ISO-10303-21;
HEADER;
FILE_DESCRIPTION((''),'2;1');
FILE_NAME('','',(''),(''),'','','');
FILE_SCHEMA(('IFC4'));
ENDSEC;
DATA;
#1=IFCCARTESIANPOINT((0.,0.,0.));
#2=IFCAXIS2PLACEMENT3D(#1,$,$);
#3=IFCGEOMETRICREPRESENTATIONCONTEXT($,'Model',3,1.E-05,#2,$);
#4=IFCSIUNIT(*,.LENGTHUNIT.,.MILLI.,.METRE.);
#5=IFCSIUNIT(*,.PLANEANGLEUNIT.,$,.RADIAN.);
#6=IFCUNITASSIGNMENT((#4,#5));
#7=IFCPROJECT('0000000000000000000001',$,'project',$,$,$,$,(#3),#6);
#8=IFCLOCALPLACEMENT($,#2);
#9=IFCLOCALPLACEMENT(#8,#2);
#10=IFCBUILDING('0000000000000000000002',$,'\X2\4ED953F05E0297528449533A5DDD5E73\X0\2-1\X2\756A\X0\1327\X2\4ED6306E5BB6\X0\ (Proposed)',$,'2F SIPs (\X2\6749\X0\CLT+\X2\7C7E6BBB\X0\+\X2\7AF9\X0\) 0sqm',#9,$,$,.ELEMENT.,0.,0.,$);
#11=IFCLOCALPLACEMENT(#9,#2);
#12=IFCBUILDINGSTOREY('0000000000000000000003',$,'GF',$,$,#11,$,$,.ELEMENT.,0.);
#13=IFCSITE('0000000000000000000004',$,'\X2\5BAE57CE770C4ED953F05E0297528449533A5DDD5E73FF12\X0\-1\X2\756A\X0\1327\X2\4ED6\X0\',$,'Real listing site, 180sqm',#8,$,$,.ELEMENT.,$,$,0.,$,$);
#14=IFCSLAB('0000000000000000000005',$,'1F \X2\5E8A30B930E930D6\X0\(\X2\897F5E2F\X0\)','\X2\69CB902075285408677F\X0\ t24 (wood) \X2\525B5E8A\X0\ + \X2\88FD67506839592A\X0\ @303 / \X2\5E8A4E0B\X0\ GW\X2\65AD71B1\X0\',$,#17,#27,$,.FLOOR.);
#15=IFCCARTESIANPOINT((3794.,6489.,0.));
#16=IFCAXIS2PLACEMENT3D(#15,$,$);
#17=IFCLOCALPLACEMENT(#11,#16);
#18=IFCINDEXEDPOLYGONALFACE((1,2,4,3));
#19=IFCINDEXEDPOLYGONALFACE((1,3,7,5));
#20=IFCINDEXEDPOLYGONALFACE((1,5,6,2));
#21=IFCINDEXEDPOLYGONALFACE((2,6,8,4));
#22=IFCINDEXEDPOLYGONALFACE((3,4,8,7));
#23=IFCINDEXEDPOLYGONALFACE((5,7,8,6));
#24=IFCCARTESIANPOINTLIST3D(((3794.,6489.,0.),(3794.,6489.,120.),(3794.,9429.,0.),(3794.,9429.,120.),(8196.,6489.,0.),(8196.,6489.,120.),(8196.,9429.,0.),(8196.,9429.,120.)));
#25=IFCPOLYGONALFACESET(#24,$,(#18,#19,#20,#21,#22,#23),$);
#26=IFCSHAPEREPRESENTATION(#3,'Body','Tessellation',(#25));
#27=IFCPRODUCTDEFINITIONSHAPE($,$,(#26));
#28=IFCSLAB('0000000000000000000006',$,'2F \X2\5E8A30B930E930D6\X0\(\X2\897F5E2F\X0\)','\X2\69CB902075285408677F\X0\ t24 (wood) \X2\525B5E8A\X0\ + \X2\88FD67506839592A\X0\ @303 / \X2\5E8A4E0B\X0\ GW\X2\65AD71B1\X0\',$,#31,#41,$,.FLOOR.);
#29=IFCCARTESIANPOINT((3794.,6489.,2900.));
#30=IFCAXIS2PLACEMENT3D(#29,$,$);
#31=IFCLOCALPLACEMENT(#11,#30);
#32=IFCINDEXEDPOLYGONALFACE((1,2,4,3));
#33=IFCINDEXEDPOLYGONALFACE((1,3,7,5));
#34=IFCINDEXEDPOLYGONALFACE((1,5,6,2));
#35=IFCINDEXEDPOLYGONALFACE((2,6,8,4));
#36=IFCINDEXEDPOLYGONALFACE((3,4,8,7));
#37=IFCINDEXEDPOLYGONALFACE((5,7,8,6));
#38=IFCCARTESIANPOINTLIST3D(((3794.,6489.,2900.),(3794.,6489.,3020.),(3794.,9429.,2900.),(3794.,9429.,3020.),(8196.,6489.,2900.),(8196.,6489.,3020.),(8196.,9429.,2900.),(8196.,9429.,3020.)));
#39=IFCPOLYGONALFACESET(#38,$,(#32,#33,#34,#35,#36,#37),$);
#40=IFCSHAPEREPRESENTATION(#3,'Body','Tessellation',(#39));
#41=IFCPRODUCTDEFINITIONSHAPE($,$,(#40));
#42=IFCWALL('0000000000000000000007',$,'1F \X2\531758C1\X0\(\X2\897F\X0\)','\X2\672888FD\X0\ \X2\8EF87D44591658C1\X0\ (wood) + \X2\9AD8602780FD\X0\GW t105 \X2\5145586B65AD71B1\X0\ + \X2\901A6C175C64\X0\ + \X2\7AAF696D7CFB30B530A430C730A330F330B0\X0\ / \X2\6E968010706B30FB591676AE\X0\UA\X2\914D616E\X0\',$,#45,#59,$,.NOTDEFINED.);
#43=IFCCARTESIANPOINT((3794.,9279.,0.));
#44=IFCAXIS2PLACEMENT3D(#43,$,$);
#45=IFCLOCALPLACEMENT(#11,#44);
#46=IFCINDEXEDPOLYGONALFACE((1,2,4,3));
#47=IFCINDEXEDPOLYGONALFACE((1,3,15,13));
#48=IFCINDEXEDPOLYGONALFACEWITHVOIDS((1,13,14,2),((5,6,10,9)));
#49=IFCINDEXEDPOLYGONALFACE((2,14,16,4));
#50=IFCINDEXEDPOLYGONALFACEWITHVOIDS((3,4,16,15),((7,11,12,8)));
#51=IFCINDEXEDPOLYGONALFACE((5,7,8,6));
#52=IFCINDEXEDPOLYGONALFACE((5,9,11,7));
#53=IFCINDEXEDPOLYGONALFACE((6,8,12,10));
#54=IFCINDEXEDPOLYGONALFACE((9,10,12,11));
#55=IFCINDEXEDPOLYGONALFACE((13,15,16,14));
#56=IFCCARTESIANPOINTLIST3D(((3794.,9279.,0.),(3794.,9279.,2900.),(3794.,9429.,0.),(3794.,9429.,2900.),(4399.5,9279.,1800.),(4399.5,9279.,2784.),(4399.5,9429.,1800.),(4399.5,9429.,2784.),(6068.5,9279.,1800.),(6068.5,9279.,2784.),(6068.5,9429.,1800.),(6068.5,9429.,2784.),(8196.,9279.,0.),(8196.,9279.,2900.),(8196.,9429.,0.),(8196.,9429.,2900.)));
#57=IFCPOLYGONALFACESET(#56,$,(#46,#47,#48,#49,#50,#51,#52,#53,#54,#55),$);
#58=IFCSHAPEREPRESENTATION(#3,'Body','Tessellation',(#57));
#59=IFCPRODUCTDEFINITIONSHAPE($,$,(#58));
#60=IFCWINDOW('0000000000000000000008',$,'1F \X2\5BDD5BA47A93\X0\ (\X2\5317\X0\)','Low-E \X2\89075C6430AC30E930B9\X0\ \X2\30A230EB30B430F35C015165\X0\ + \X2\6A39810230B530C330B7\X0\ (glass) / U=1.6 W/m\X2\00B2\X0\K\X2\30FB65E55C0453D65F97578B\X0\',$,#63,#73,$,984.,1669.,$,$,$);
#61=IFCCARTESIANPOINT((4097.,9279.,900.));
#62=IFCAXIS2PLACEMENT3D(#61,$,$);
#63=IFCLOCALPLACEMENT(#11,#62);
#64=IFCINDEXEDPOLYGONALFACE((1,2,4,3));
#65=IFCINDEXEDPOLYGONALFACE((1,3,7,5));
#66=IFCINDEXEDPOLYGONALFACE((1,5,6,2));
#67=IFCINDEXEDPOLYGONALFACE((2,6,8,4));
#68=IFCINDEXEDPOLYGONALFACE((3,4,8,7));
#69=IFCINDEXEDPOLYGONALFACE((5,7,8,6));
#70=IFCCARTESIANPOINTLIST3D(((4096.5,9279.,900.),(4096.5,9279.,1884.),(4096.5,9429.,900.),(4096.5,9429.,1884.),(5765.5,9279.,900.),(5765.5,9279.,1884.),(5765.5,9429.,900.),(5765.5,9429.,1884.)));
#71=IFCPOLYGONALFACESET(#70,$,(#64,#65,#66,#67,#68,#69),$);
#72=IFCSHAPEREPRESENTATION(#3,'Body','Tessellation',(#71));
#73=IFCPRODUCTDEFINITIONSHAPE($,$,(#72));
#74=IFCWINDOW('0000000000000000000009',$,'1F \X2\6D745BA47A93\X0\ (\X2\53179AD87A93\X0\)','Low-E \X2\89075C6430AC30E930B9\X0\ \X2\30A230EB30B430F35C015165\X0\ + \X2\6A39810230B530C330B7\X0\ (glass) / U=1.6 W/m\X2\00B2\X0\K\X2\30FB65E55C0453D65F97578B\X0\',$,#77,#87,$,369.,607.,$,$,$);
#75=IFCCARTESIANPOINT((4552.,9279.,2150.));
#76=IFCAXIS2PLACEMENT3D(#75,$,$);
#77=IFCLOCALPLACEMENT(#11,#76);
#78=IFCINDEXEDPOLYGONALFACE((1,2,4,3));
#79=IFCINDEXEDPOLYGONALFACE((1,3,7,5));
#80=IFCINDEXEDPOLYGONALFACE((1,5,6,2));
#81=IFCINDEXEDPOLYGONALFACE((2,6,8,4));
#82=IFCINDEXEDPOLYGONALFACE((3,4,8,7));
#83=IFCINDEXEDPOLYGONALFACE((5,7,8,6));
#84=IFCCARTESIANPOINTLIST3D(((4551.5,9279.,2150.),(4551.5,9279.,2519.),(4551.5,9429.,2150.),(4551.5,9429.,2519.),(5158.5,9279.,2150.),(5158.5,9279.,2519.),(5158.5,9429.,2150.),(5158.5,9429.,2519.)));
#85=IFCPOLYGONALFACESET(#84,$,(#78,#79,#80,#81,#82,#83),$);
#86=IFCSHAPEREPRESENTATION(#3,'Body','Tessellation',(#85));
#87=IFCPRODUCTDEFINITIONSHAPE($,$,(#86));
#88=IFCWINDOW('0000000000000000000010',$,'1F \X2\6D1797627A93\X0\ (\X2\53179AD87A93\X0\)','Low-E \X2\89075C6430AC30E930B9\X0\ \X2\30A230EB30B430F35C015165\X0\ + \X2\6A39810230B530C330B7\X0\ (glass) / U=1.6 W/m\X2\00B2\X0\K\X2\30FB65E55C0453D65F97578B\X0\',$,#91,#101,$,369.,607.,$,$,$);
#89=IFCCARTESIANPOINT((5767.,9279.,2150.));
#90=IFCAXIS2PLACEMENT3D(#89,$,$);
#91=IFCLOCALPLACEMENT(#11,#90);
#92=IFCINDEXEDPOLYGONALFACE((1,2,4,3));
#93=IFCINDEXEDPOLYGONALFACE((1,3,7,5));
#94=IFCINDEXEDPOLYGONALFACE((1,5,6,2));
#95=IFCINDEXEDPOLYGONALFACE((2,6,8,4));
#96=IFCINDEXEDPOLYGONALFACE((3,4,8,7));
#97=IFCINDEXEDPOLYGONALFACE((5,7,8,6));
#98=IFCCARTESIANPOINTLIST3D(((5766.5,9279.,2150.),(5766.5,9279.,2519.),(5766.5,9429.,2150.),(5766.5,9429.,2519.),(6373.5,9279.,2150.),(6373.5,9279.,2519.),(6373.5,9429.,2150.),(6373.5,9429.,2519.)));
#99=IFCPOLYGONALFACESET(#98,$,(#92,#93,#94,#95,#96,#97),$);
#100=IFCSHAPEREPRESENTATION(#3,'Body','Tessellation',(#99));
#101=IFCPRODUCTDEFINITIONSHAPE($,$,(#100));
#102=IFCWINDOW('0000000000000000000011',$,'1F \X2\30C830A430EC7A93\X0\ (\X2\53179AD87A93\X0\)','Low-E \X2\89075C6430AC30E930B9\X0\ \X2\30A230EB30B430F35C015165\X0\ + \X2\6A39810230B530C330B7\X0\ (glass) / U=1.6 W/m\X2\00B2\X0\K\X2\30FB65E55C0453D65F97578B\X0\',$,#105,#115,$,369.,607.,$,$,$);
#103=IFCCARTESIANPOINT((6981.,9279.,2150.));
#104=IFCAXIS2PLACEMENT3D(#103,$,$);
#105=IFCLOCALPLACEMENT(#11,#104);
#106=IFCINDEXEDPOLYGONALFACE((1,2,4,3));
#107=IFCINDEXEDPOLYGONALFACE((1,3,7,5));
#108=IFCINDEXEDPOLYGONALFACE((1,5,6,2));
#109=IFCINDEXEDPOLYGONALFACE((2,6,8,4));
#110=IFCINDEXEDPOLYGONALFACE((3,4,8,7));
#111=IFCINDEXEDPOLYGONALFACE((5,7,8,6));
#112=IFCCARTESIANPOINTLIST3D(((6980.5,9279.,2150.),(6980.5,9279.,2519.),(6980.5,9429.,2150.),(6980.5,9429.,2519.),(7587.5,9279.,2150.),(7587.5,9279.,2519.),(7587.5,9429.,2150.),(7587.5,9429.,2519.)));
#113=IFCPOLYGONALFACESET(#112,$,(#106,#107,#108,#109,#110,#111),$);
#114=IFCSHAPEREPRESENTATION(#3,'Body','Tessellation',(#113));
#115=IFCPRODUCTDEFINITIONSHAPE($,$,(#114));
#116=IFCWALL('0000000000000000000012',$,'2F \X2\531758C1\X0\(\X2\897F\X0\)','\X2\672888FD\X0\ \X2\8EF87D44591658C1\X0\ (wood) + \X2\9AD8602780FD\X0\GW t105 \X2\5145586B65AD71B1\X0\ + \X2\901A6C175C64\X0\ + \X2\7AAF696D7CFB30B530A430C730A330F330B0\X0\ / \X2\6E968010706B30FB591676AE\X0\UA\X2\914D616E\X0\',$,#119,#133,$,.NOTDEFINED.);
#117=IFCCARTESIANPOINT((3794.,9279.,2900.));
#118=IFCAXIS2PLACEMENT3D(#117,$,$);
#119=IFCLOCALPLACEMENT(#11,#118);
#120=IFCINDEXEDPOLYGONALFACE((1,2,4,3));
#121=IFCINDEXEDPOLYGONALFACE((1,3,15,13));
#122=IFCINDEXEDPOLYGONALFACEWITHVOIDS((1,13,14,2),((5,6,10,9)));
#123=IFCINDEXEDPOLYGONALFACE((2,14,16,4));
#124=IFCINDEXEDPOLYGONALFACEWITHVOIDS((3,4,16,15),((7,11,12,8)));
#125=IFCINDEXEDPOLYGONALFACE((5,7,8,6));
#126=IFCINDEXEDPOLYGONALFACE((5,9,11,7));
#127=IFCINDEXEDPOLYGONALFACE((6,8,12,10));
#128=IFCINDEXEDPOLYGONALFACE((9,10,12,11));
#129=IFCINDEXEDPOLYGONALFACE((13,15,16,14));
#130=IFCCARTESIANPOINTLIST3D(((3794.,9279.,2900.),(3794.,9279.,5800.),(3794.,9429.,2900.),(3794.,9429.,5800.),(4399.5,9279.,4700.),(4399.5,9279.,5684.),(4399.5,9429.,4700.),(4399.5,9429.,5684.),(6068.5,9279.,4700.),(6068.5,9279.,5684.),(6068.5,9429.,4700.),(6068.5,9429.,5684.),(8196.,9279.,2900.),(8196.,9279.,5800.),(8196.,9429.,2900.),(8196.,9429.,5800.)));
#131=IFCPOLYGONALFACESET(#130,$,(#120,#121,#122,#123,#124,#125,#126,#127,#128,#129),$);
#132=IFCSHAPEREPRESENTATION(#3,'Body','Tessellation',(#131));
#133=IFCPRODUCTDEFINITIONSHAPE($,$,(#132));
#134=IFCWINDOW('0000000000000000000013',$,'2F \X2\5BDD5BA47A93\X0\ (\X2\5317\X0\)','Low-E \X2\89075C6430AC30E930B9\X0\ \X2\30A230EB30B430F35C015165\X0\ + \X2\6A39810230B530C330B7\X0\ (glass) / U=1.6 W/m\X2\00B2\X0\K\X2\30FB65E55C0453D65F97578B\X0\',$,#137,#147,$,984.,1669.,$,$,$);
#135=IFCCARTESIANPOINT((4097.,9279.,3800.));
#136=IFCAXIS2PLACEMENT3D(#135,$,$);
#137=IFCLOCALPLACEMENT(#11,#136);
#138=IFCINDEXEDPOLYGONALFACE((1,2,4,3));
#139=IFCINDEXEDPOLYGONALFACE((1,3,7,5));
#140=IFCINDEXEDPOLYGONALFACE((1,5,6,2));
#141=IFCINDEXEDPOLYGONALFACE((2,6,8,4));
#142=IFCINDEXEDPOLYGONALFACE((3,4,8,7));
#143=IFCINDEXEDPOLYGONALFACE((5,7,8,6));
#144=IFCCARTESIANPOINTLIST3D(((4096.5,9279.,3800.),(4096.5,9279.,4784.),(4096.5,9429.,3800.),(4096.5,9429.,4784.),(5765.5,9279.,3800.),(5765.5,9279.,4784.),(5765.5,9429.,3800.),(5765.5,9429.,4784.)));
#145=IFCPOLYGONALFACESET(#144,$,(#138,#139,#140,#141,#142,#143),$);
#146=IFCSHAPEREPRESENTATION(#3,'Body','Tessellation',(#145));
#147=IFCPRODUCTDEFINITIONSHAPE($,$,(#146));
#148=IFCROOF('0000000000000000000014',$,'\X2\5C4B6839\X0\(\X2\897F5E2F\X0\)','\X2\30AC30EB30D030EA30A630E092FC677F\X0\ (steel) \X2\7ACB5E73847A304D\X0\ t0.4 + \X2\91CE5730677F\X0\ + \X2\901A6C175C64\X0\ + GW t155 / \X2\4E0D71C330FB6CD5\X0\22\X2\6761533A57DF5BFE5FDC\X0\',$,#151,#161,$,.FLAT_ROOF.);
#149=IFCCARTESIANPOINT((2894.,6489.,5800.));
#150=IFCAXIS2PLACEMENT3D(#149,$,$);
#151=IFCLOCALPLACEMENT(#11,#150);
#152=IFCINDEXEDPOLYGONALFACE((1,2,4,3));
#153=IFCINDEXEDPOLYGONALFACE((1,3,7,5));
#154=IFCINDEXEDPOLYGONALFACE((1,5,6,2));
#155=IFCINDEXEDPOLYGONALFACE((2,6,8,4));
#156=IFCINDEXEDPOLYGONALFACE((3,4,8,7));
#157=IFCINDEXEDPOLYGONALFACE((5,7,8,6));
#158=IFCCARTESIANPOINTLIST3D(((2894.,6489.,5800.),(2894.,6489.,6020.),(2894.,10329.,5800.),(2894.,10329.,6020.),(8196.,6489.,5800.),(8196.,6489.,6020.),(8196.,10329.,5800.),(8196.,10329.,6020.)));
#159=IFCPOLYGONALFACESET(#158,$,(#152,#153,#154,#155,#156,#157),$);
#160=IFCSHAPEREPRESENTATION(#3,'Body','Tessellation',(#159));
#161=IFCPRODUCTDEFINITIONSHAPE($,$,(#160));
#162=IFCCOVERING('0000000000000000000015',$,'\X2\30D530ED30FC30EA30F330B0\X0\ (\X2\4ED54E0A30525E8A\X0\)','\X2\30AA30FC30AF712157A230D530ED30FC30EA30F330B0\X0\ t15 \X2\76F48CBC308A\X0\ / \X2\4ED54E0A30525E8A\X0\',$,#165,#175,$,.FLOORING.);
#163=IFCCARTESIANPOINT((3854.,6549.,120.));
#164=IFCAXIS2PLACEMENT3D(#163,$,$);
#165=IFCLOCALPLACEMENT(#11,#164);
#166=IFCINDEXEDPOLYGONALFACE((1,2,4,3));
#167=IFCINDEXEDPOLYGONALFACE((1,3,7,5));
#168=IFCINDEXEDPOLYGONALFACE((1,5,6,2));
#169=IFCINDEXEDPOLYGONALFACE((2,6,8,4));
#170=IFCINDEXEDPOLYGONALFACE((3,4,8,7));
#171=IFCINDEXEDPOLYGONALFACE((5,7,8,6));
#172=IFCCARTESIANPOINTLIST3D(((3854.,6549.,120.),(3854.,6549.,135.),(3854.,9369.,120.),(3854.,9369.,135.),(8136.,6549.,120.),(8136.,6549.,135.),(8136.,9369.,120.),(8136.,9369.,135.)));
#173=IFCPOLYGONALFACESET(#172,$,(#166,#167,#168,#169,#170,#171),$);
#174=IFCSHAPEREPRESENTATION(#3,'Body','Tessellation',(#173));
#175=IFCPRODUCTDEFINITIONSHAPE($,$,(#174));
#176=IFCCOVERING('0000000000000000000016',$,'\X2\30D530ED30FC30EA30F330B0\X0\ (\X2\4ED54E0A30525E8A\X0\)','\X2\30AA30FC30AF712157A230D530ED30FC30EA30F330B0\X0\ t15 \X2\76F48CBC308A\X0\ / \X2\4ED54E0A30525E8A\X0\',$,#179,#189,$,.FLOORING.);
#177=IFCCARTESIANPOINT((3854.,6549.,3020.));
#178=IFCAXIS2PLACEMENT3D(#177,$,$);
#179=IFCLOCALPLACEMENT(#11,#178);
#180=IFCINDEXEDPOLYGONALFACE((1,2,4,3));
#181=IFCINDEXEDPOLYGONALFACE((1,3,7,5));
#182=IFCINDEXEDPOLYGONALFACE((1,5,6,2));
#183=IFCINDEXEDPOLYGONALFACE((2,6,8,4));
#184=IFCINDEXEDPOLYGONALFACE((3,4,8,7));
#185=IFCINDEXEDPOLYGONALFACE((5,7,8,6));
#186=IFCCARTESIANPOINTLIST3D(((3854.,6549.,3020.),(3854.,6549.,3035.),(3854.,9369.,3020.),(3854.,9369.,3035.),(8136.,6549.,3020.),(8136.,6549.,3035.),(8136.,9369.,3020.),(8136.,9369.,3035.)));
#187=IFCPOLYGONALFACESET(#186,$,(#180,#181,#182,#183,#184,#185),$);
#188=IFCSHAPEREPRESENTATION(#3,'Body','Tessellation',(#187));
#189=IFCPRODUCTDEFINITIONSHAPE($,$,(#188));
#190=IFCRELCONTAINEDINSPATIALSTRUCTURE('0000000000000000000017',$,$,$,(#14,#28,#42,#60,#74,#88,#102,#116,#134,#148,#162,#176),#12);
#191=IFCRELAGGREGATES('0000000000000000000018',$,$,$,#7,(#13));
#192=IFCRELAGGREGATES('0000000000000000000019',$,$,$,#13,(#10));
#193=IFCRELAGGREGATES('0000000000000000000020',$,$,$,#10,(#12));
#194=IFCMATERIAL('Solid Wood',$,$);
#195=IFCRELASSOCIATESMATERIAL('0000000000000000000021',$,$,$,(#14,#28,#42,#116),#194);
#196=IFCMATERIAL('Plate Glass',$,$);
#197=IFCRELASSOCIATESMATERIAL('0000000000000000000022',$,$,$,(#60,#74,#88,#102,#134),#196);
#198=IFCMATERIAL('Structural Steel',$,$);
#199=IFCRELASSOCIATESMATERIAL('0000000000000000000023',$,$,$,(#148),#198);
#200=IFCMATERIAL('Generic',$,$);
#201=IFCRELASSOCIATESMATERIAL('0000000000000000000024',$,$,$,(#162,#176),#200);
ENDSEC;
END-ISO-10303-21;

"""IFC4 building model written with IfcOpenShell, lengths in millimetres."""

from ifc_helpers import new_model, si_unit, frame, frame_2d, origin, place, context, project, spatial, rectangle, extrude, material, element, fill, save


model = new_model("IFC4")

# Units and contexts
model_context = context("Model", 3, precision=1e-05, world=origin())
ifc_project = project(units=[si_unit("LENGTHUNIT", "METRE", prefix="MILLI"), si_unit("PLANEANGLEUNIT", "RADIAN")], contexts=[model_context])

# Site, building, storey
site_placement = place(None, origin())
site = spatial("IfcSite", under=ifc_project, at=site_placement, Name="宮城県仙台市青葉区川平２-1番1327他", ObjectType="Real listing site, 180sqm", CompositionType="ELEMENT", RefElevation=0.0)
building_placement = place(site_placement, origin())
building = spatial("IfcBuilding", under=site, at=building_placement, Name="仙台市青葉区川平2-1番1327他の家 (Proposed)", ObjectType="2F SIPs (杉CLT+籾殻+竹) 0sqm", CompositionType="ELEMENT", ElevationOfRefHeight=0.0, ElevationOfTerrain=0.0)
storey_placement = place(building_placement, origin())
storey = spatial("IfcBuildingStorey", under=building, at=storey_placement, Name="GF", CompositionType="ELEMENT", Elevation=0.0)

# Slabs
ifc_material_1 = material(Name="Solid Wood")
slab_1_placement = place(storey_placement, frame((3794.0, 6489.0, 0.0)))
element("IfcSlab", 1, at=slab_1_placement, inside=storey, material=ifc_material_1, Name="1F 床スラブ(西帯)", Description="構造用合板 t24 (wood) 剛床 + 製材根太 @303 / 床下 GW断熱", PredefinedType="FLOOR", context=model_context, shape_type="SweptSolid", body=[
    extrude(rectangle(XDim=4402.0, YDim=2940.0, at=frame_2d((2201.0, 1470.0))), frame((3794.0, 6489.0, 0.0)), (0.0, 0.0, 1.0), 120.0),
])
slab_2_placement = place(storey_placement, frame((3794.0, 6489.0, 2900.0)))
element("IfcSlab", 2, at=slab_2_placement, inside=storey, material=ifc_material_1, Name="2F 床スラブ(西帯)", Description="構造用合板 t24 (wood) 剛床 + 製材根太 @303 / 床下 GW断熱", PredefinedType="FLOOR", context=model_context, shape_type="SweptSolid", body=[
    extrude(rectangle(XDim=4402.0, YDim=2940.0, at=frame_2d((2201.0, 1470.0))), frame((3794.0, 6489.0, 2900.0)), (0.0, 0.0, 1.0), 120.0),
])

# Wall, openings, windows
wall_1_placement = place(storey_placement, frame((3794.0, 9279.0, 0.0)))
wall_1 = element("IfcWall", 3, at=wall_1_placement, inside=storey, material=ifc_material_1, Name="1F 北壁(西)", Description="木製 軸組外壁 (wood) + 高性能GW t105 充填断熱 + 通気層 + 窯業系サイディング / 準耐火・外皮UA配慮", PredefinedType="NOTDEFINED", context=model_context, shape_type="SweptSolid", body=[
    extrude(rectangle(XDim=4402.0, YDim=150.0, at=frame_2d((2201.0, 75.0))), frame((3794.0, 9279.0, 0.0)), (0.0, 0.0, 1.0), 2900.0),
])
opening_1_placement = place(storey_placement, frame((4097.0, 9279.0, 900.0)))
opening_1 = element("IfcOpeningElement", 4, at=opening_1_placement, cuts=wall_1, PredefinedType="NOTDEFINED", context=model_context, shape_type="SweptSolid", body=[
    extrude(rectangle(XDim=1669.0, YDim=150.0, at=frame_2d((834.0, 75.0))), frame((4097.0, 9279.0, 900.0)), (0.0, 0.0, 1.0), 984.0),
])
opening_2_placement = place(storey_placement, frame((4552.0, 9279.0, 2150.0)))
opening_2 = element("IfcOpeningElement", 5, at=opening_2_placement, cuts=wall_1, PredefinedType="NOTDEFINED", context=model_context, shape_type="SweptSolid", body=[
    extrude(rectangle(XDim=607.0, YDim=150.0, at=frame_2d((303.0, 75.0))), frame((4552.0, 9279.0, 2150.0)), (0.0, 0.0, 1.0), 369.0),
])
opening_3_placement = place(storey_placement, frame((5767.0, 9279.0, 2150.0)))
opening_3 = element("IfcOpeningElement", 6, at=opening_3_placement, cuts=wall_1, PredefinedType="NOTDEFINED", context=model_context, shape_type="SweptSolid", body=[
    extrude(rectangle(XDim=607.0, YDim=150.0, at=frame_2d((303.0, 75.0))), frame((5767.0, 9279.0, 2150.0)), (0.0, 0.0, 1.0), 369.0),
])
opening_4_placement = place(storey_placement, frame((6981.0, 9279.0, 2150.0)))
opening_4 = element("IfcOpeningElement", 7, at=opening_4_placement, cuts=wall_1, PredefinedType="NOTDEFINED", context=model_context, shape_type="SweptSolid", body=[
    extrude(rectangle(XDim=607.0, YDim=150.0, at=frame_2d((303.0, 75.0))), frame((6981.0, 9279.0, 2150.0)), (0.0, 0.0, 1.0), 369.0),
])
ifc_material_2 = material(Name="Plate Glass")
window_1_placement = place(storey_placement, frame((4097.0, 9279.0, 900.0)))
window_1 = element("IfcWindow", 8, at=window_1_placement, inside=storey, material=ifc_material_2, Name="1F 寝室窓 (北)", Description="Low-E 複層ガラス アルゴン封入 + 樹脂サッシ (glass) / U=1.6 W/m²K・日射取得型", OverallHeight=984.0, OverallWidth=1669.0, context=model_context, shape_type="SweptSolid", body=[
    extrude(rectangle(XDim=1669.0, YDim=150.0, at=frame_2d((834.0, 75.0))), frame((4097.0, 9279.0, 900.0)), (0.0, 0.0, 1.0), 984.0),
])
fill(opening_1, window_1)
window_2_placement = place(storey_placement, frame((4552.0, 9279.0, 2150.0)))
window_2 = element("IfcWindow", 9, at=window_2_placement, inside=storey, material=ifc_material_2, Name="1F 浴室窓 (北高窓)", Description="Low-E 複層ガラス アルゴン封入 + 樹脂サッシ (glass) / U=1.6 W/m²K・日射取得型", OverallHeight=369.0, OverallWidth=607.0, context=model_context, shape_type="SweptSolid", body=[
    extrude(rectangle(XDim=607.0, YDim=150.0, at=frame_2d((303.0, 75.0))), frame((4552.0, 9279.0, 2150.0)), (0.0, 0.0, 1.0), 369.0),
])
fill(opening_2, window_2)
window_3_placement = place(storey_placement, frame((5767.0, 9279.0, 2150.0)))
window_3 = element("IfcWindow", 10, at=window_3_placement, inside=storey, material=ifc_material_2, Name="1F 洗面窓 (北高窓)", Description="Low-E 複層ガラス アルゴン封入 + 樹脂サッシ (glass) / U=1.6 W/m²K・日射取得型", OverallHeight=369.0, OverallWidth=607.0, context=model_context, shape_type="SweptSolid", body=[
    extrude(rectangle(XDim=607.0, YDim=150.0, at=frame_2d((303.0, 75.0))), frame((5767.0, 9279.0, 2150.0)), (0.0, 0.0, 1.0), 369.0),
])
fill(opening_3, window_3)
window_4_placement = place(storey_placement, frame((6981.0, 9279.0, 2150.0)))
window_4 = element("IfcWindow", 11, at=window_4_placement, inside=storey, material=ifc_material_2, Name="1F トイレ窓 (北高窓)", Description="Low-E 複層ガラス アルゴン封入 + 樹脂サッシ (glass) / U=1.6 W/m²K・日射取得型", OverallHeight=369.0, OverallWidth=607.0, context=model_context, shape_type="SweptSolid", body=[
    extrude(rectangle(XDim=607.0, YDim=150.0, at=frame_2d((303.0, 75.0))), frame((6981.0, 9279.0, 2150.0)), (0.0, 0.0, 1.0), 369.0),
])
fill(opening_4, window_4)

# Wall, opening, window
wall_2_placement = place(storey_placement, frame((3794.0, 9279.0, 2900.0)))
wall_2 = element("IfcWall", 12, at=wall_2_placement, inside=storey, material=ifc_material_1, Name="2F 北壁(西)", Description="木製 軸組外壁 (wood) + 高性能GW t105 充填断熱 + 通気層 + 窯業系サイディング / 準耐火・外皮UA配慮", PredefinedType="NOTDEFINED", context=model_context, shape_type="SweptSolid", body=[
    extrude(rectangle(XDim=4402.0, YDim=150.0, at=frame_2d((2201.0, 75.0))), frame((3794.0, 9279.0, 2900.0)), (0.0, 0.0, 1.0), 2900.0),
])
opening_5_placement = place(storey_placement, frame((4097.0, 9279.0, 3800.0)))
opening_5 = element("IfcOpeningElement", 13, at=opening_5_placement, cuts=wall_2, PredefinedType="NOTDEFINED", context=model_context, shape_type="SweptSolid", body=[
    extrude(rectangle(XDim=1669.0, YDim=150.0, at=frame_2d((834.0, 75.0))), frame((4097.0, 9279.0, 3800.0)), (0.0, 0.0, 1.0), 984.0),
])
window_5_placement = place(storey_placement, frame((4097.0, 9279.0, 3800.0)))
window_5 = element("IfcWindow", 14, at=window_5_placement, inside=storey, material=ifc_material_2, Name="2F 寝室窓 (北)", Description="Low-E 複層ガラス アルゴン封入 + 樹脂サッシ (glass) / U=1.6 W/m²K・日射取得型", OverallHeight=984.0, OverallWidth=1669.0, context=model_context, shape_type="SweptSolid", body=[
    extrude(rectangle(XDim=1669.0, YDim=150.0, at=frame_2d((834.0, 75.0))), frame((4097.0, 9279.0, 3800.0)), (0.0, 0.0, 1.0), 984.0),
])
fill(opening_5, window_5)

# Roof
ifc_material_3 = material(Name="Structural Steel")
for number, where, name in (
    (15, (2894.0, 6489.0, 5800.0), "屋根(西帯)"),
):
    element("IfcRoof", number, at=place(storey_placement, frame(where)), inside=storey, material=ifc_material_3, Name=name, Description="ガルバリウム鋼板 (steel) 立平葺き t0.4 + 野地板 + 通気層 + GW t155 / 不燃・法22条区域対応", PredefinedType="FLAT_ROOF", context=model_context, shape_type="SweptSolid", body=[
        extrude(rectangle(XDim=5302.0, YDim=3840.0, at=frame_2d((2651.0, 1920.0))), frame((2894.0, 6489.0, 5800.0)), (0.0, 0.0, 1.0), 220.0),
    ])

# Coverings
ifc_material_4 = material(Name="Generic")
covering_1_placement = place(storey_placement, frame((3854.0, 6549.0, 120.0)))
element("IfcCovering", 16, at=covering_1_placement, inside=storey, material=ifc_material_4, Name="フローリング (仕上げ床)", Description="オーク無垢フローリング t15 直貼り / 仕上げ床", PredefinedType="FLOORING", context=model_context, shape_type="SweptSolid", body=[
    extrude(rectangle(XDim=4282.0, YDim=2820.0, at=frame_2d((2141.0, 1410.0))), frame((3854.0, 6549.0, 120.0)), (0.0, 0.0, 1.0), 15.0),
])
covering_2_placement = place(storey_placement, frame((3854.0, 6549.0, 3020.0)))
element("IfcCovering", 17, at=covering_2_placement, inside=storey, material=ifc_material_4, Name="フローリング (仕上げ床)", Description="オーク無垢フローリング t15 直貼り / 仕上げ床", PredefinedType="FLOORING", context=model_context, shape_type="SweptSolid", body=[
    extrude(rectangle(XDim=4282.0, YDim=2820.0, at=frame_2d((2141.0, 1410.0))), frame((3854.0, 6549.0, 3020.0)), (0.0, 0.0, 1.0), 15.0),
])

save(model, "model.ifc")
